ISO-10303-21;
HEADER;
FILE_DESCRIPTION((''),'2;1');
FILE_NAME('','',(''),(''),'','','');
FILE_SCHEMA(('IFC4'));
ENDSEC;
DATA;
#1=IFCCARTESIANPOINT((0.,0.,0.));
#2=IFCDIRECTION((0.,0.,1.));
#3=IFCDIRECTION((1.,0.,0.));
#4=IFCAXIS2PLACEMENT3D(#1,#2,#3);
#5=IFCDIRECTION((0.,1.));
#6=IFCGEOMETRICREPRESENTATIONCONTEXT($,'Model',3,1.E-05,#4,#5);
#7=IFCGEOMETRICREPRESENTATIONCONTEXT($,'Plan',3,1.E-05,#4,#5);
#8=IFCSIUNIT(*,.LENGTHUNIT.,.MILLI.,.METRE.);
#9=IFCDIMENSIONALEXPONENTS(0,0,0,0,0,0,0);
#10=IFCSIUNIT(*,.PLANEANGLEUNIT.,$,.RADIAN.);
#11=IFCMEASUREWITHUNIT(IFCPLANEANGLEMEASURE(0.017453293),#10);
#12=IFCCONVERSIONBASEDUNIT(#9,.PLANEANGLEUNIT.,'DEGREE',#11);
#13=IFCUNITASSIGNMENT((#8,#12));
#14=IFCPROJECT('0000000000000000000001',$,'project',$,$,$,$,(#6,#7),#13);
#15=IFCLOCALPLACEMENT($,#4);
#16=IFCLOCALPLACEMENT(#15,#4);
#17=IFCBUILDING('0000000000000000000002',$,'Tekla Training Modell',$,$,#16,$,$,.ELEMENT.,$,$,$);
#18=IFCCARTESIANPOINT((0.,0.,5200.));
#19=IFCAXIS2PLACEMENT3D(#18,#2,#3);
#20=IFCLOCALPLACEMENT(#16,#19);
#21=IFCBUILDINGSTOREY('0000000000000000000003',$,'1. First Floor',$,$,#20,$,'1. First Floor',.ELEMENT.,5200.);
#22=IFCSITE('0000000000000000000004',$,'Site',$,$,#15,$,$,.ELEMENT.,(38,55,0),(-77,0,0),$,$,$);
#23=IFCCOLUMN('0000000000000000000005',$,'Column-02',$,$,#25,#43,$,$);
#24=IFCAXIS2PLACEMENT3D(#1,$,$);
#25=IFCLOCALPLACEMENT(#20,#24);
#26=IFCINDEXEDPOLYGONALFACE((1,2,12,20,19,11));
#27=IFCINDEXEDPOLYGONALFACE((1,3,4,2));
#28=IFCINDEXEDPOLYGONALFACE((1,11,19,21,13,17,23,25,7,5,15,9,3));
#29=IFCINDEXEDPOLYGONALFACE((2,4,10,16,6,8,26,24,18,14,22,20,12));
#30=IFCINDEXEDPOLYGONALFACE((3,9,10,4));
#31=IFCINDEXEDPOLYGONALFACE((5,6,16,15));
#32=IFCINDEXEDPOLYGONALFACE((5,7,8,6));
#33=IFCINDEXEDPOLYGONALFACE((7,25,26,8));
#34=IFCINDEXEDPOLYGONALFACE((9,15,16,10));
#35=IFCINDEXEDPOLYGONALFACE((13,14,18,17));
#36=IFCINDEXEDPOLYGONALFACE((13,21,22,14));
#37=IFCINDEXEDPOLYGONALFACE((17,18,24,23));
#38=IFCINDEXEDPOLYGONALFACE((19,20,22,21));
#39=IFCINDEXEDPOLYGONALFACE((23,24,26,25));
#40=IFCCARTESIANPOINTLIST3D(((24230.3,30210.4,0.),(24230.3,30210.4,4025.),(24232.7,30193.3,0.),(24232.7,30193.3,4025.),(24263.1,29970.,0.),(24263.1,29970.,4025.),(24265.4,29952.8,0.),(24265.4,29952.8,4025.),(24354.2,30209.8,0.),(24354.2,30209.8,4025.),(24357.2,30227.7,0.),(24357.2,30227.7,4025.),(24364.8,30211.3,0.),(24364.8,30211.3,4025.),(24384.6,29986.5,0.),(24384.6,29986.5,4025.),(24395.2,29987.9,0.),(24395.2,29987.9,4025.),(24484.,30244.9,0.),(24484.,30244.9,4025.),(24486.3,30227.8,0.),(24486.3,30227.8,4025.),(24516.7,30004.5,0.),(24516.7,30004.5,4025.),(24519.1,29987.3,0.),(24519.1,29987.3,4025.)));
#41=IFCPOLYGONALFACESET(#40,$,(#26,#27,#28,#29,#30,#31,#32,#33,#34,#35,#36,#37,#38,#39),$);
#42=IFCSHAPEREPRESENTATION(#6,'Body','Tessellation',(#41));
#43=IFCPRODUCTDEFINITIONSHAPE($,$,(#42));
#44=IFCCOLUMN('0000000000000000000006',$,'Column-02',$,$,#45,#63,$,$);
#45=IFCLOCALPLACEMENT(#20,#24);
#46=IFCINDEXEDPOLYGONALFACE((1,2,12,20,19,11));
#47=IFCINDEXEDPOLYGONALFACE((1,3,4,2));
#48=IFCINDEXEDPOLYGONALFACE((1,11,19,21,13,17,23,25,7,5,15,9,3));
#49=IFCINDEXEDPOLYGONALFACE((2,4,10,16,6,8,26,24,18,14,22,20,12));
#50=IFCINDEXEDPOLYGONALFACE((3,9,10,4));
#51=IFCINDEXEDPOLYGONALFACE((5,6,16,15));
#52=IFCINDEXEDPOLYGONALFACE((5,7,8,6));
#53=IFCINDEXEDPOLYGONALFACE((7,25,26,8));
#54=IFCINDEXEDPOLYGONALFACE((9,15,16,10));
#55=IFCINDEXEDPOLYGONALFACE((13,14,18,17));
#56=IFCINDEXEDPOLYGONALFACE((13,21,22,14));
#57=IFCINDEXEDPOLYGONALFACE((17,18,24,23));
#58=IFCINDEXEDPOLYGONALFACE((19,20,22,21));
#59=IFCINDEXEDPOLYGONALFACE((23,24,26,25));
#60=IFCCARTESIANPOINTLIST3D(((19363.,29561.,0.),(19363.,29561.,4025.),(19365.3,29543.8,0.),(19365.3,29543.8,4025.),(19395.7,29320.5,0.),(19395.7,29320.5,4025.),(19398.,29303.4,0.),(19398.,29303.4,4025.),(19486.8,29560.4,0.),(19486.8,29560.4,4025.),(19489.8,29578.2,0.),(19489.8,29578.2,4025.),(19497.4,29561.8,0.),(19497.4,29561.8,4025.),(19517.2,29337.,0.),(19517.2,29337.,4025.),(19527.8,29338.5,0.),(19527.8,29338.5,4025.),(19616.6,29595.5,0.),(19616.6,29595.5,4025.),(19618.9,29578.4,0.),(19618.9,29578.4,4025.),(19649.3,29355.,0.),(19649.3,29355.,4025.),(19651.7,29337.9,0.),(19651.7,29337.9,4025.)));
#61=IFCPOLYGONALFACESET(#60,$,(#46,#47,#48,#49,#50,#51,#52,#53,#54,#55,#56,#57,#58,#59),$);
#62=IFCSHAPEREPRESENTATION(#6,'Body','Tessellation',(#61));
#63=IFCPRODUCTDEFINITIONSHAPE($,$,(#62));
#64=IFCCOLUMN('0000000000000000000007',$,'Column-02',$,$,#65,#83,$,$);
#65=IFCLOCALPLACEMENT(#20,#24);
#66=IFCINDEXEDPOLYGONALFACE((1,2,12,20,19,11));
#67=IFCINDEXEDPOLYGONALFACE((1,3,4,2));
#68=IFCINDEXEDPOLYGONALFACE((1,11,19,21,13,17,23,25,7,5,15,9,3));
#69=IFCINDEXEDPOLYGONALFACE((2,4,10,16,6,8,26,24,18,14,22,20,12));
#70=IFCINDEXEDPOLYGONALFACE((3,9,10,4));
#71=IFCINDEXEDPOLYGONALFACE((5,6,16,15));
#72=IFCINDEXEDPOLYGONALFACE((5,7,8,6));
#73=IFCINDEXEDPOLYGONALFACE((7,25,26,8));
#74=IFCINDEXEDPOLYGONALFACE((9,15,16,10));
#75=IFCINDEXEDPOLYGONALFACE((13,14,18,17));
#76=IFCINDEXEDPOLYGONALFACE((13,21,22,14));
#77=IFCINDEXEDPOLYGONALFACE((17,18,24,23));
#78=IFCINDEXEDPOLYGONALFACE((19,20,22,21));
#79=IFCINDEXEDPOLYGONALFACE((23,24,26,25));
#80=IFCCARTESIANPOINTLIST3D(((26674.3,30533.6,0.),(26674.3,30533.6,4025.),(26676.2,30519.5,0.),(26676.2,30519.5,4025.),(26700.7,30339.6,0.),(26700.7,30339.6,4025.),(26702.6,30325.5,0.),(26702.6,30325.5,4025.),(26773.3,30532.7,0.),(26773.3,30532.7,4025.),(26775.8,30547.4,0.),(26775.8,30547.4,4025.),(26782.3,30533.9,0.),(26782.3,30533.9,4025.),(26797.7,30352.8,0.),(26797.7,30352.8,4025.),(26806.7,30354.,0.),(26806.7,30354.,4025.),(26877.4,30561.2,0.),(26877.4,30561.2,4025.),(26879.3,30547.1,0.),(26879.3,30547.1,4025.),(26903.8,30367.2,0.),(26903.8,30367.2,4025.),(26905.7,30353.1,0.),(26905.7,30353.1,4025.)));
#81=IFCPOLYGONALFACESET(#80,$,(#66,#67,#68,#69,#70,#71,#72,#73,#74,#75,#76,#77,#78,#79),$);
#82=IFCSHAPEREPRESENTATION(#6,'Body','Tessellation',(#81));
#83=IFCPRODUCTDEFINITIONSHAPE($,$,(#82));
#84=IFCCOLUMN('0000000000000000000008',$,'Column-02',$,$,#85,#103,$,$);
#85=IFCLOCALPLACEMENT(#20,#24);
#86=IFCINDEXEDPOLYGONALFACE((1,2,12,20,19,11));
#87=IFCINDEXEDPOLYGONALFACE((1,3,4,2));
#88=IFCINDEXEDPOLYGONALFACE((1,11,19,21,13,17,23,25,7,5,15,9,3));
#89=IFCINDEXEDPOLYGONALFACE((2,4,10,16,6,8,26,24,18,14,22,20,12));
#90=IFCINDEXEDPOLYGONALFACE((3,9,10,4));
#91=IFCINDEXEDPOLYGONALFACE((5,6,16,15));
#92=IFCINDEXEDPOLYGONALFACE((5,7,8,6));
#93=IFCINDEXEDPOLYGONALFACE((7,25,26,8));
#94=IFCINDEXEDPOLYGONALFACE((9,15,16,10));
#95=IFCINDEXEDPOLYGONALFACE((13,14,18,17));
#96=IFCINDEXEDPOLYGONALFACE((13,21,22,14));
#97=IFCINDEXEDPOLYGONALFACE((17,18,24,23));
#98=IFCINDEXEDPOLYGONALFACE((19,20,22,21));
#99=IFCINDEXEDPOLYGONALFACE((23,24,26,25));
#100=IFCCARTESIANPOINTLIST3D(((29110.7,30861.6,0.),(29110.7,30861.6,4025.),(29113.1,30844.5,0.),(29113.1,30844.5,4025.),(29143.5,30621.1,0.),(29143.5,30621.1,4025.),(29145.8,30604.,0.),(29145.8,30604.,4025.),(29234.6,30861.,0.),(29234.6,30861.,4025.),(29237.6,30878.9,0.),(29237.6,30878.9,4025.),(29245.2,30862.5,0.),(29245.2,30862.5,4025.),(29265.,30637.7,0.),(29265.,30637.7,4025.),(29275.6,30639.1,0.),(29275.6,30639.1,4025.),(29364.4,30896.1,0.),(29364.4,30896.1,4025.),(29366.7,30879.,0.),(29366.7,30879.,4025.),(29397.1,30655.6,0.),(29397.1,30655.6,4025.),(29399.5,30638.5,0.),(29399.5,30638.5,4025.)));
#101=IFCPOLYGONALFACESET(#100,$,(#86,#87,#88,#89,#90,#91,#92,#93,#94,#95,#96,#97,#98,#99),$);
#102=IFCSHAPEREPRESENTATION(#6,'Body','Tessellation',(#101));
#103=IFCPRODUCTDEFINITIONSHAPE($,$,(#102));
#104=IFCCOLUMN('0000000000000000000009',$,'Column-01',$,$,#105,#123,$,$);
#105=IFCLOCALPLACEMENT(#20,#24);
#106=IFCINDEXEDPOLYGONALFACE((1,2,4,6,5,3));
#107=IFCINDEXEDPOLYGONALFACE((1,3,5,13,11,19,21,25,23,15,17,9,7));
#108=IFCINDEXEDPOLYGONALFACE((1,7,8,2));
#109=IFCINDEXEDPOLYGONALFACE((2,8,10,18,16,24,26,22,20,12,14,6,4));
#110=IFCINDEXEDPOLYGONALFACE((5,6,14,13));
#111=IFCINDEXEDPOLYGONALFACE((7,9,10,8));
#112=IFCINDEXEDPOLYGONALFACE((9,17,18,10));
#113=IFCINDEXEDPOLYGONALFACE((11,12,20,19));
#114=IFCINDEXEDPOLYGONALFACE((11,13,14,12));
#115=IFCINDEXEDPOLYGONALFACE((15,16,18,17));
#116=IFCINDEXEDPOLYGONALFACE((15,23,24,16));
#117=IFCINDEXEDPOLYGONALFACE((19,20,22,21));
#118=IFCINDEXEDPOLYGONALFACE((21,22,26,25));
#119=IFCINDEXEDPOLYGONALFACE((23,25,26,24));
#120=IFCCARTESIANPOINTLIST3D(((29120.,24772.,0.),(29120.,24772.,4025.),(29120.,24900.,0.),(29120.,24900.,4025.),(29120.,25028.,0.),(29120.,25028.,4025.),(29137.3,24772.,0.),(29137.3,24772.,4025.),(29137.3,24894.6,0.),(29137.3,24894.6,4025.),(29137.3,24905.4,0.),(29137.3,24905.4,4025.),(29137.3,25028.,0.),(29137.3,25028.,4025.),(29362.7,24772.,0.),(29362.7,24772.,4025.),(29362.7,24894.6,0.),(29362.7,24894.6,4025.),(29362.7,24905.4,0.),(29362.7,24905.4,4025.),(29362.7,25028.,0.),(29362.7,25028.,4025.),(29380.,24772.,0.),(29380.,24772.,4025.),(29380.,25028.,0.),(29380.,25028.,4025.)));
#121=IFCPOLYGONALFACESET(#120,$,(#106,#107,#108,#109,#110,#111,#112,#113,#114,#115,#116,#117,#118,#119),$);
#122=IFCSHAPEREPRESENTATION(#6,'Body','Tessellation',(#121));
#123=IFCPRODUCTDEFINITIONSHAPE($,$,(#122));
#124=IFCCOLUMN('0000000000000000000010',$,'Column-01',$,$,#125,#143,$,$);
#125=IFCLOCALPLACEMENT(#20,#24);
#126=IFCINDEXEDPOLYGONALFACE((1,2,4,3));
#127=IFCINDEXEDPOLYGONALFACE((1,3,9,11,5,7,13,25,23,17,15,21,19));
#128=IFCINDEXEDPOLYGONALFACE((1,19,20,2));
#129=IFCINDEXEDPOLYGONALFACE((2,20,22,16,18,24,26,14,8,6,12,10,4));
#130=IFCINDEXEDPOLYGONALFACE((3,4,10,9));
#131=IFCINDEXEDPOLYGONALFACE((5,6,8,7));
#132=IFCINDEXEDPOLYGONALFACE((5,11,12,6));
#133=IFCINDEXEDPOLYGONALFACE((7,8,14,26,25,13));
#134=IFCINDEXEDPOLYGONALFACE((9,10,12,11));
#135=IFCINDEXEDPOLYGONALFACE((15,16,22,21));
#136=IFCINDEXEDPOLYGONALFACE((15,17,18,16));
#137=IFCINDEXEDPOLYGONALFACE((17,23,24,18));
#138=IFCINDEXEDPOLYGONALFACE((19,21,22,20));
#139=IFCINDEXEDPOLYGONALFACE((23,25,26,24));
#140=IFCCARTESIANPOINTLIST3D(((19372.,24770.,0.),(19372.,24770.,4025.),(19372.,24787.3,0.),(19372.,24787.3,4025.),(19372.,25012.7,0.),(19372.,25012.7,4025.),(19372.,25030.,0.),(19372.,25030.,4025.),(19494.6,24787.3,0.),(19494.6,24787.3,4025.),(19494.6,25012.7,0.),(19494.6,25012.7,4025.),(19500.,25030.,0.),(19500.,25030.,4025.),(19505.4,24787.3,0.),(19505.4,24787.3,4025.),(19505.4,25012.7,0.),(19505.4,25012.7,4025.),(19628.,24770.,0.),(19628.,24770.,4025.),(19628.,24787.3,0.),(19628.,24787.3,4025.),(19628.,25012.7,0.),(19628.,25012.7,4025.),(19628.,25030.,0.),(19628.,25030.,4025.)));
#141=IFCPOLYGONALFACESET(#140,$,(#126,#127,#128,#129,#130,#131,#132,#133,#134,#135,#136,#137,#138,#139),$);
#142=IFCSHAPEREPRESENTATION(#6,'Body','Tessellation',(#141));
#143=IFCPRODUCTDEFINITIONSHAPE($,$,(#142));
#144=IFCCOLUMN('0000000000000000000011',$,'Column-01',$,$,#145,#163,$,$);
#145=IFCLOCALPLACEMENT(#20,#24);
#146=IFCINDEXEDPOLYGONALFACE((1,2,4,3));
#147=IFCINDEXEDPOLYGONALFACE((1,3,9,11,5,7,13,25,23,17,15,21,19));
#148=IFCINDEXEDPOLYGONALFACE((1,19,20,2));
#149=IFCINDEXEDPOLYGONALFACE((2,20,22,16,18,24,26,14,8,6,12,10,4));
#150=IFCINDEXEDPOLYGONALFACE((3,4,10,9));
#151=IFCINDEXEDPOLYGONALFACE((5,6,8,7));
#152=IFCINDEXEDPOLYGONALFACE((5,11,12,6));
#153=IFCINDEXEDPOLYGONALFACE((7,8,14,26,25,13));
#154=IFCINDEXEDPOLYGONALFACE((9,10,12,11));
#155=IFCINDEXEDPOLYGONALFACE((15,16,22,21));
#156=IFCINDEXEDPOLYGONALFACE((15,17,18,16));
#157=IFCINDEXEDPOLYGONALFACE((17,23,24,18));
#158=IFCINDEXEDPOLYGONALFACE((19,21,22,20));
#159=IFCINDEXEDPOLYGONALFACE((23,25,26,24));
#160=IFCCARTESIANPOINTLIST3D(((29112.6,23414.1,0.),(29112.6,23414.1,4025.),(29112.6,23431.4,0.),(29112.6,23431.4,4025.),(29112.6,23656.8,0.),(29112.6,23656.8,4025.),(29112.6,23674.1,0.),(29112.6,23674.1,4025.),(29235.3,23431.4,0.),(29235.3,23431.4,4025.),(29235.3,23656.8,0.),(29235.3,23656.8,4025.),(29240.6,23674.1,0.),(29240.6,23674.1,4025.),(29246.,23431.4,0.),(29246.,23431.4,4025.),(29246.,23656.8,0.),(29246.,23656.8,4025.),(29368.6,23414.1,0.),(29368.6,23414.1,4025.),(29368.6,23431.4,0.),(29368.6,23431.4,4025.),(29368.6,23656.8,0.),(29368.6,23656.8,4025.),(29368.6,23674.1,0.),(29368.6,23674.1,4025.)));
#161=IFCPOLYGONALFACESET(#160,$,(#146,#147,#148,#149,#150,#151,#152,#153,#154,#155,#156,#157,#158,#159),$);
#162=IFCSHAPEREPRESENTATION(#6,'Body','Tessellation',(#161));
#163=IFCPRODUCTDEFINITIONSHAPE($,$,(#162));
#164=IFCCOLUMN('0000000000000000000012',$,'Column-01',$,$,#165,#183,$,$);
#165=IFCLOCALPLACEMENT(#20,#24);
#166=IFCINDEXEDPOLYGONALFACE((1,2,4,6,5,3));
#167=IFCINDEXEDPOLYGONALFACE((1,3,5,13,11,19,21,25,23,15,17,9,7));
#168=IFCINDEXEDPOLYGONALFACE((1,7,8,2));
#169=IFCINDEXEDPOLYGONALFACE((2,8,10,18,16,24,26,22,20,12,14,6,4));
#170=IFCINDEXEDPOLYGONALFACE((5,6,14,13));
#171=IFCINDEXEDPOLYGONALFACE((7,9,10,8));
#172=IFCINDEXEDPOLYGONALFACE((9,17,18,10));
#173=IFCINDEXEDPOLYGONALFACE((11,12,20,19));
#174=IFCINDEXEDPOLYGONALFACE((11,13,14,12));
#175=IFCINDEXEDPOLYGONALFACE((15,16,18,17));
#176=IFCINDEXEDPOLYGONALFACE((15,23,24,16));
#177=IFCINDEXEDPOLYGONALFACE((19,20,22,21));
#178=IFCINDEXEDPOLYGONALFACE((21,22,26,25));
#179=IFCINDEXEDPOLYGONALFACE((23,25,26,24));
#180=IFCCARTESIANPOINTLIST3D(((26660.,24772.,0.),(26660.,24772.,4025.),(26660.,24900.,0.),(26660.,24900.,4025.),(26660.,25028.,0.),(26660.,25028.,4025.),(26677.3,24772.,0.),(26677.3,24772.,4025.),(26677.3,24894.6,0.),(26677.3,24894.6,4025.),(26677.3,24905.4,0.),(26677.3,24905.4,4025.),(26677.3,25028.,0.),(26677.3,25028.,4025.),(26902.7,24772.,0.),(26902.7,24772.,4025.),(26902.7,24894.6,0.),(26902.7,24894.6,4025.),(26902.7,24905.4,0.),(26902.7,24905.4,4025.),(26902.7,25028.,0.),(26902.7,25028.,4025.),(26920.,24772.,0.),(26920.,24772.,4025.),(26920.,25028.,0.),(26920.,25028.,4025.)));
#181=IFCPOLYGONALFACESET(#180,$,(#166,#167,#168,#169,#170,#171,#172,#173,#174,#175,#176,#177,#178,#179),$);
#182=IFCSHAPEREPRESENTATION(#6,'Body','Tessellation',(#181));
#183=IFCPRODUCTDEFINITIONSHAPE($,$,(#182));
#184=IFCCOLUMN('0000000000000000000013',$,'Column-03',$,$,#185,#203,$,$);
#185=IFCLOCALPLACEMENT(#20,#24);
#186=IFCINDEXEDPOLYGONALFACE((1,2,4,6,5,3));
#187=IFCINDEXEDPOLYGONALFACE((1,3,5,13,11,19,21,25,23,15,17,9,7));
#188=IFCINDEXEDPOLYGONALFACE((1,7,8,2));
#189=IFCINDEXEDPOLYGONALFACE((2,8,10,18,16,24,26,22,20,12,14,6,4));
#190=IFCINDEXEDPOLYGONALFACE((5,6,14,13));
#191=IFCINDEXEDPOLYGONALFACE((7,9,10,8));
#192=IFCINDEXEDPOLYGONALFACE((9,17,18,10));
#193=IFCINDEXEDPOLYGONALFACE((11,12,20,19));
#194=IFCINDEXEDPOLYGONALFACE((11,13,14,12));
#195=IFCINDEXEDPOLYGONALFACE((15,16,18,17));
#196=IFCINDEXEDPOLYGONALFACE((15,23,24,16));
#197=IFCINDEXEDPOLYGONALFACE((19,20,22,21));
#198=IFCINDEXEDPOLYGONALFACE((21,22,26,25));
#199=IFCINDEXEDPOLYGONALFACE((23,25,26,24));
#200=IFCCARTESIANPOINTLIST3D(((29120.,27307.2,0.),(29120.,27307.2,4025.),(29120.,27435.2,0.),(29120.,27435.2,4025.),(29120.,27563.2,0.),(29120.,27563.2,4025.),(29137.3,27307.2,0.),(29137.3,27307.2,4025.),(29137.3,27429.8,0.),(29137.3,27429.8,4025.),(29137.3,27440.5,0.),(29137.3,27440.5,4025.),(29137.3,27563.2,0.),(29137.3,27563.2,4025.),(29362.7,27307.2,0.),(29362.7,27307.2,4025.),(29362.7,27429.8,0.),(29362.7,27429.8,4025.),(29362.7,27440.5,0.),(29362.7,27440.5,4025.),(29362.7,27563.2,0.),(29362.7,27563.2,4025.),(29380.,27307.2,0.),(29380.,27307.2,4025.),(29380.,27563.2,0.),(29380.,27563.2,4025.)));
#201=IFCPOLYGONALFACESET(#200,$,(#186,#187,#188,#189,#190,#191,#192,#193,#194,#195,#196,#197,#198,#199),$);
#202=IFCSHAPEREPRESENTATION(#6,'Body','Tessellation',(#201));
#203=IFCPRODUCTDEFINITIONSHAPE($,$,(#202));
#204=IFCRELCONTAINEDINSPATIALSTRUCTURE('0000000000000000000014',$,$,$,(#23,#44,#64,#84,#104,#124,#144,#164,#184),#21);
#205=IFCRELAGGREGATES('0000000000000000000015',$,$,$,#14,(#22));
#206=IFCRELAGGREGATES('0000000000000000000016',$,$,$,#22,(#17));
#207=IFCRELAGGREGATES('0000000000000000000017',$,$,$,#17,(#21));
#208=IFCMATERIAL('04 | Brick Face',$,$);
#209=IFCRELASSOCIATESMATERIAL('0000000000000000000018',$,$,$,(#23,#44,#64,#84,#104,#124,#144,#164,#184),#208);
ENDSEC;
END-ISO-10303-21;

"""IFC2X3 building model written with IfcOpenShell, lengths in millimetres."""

from ifc_helpers import new_model, entity, si_unit, converted_unit, direction, frame, origin_with_axes, place, context, project, spatial, polyline, outline, extrude, material, element, save


model = new_model("IFC2X3")

# Units and contexts
model_context = context("Model", 3, precision=1e-05, world=origin_with_axes(), true_north=direction((0.0, 1.0)))
plan_context = context("Plan", 3, precision=1e-05, world=origin_with_axes(), true_north=direction((0.0, 1.0)))
ifc_project = project(units=[si_unit("LENGTHUNIT", "METRE", prefix="MILLI"), converted_unit("PLANEANGLEUNIT", "DEGREE", entity("IfcPlaneAngleMeasure", 0.017453293), si_unit("PLANEANGLEUNIT", "RADIAN"), dimensions=[0, 0, 0, 0, 0, 0, 0])], contexts=[model_context, plan_context])

# Site, building, storey
site_placement = place(None, origin_with_axes())
site = spatial("IfcSite", under=ifc_project, at=site_placement, Name="Site", CompositionType="ELEMENT", RefLatitude=(38, 55, 0), RefLongitude=(-77, 0, 0))
building_placement = place(site_placement, origin_with_axes())
building = spatial("IfcBuilding", under=site, at=building_placement, Name="Tekla Training Modell", CompositionType="ELEMENT")
storey_placement = place(building_placement, frame((0.0, 0.0, 5200.0), z_axis=(0.0, 0.0, 1.0), x_axis=(1.0, 0.0, 0.0)))
storey = spatial("IfcBuildingStorey", under=building, at=storey_placement, Name="1. First Floor", LongName="1. First Floor", CompositionType="ELEMENT", Elevation=5200.0)

# Columns
ifc_material_1 = material(Name="04 | Brick Face")
for number, where, z_axis, x_axis, name in (
    (1, (24374.7, 30098.9, 0.0), (0.0, 0.0, 1.0), (0.990872, 0.134803, 0.0), "Column-02"),
    (2, (19507.3, 29449.4, 0.0), (0.0, 0.0, 1.0), (0.990872, 0.134803, 0.0), "Column-02"),
):
    element("IfcColumn", number, at=place(storey_placement, frame(where, z_axis=z_axis, x_axis=x_axis)), inside=storey, material=ifc_material_1, Name=name, context=model_context, shape_type="SweptSolid", body=[
        extrude(outline(polyline([(0.0, 130.0), (-128.0, 130.0), (-128.0, 112.7), (-5.3, 112.7), (-5.3, -112.7), (-128.0, -112.7), (-128.0, -130.0), (128.0, -130.0), (128.0, -112.7), (5.3, -112.7), (5.3, 112.7), (128.0, 112.7), (128.0, 130.0), (0.0, 130.0)])), origin_with_axes(), (0.0, 0.0, 1.0), 4025.0),
    ])
column_placement = place(storey_placement, frame((26790.0, 30443.4, 0.0), z_axis=(0.0, 0.0, 1.0), x_axis=(0.990872, 0.134803, 0.0)))
element("IfcColumn", 3, at=column_placement, inside=storey, material=ifc_material_1, Name="Column-02", context=model_context, shape_type="SweptSolid", body=[
    extrude(outline(polyline([(0.0, 105.0), (-102.5, 105.0), (-102.5, 90.8), (-4.5, 90.8), (-4.5, -90.8), (-102.5, -90.8), (-102.5, -105.0), (102.5, -105.0), (102.5, -90.8), (4.5, -90.8), (4.5, 90.8), (102.5, 90.8), (102.5, 105.0), (0.0, 105.0)])), origin_with_axes(), (0.0, 0.0, 1.0), 4025.0),
])
for number, where, z_axis, x_axis, name in (
    (4, (29255.1, 30750.1, 0.0), (0.0, 0.0, 1.0), (0.990872, 0.134803, 0.0), "Column-02"),
    (5, (29250.0, 24900.0, 0.0), (0.0, 0.0, 1.0), (0.0, 1.0, 0.0), "Column-01"),
    (6, (19500.0, 24900.0, 0.0), (0.0, 0.0, 1.0), (1.0, 0.0, 0.0), "Column-01"),
    (7, (29240.6, 23544.1, 0.0), (0.0, 0.0, 1.0), (1.0, 0.0, 0.0), "Column-01"),
    (8, (26790.0, 24900.0, 0.0), (0.0, 0.0, 1.0), (0.0, 1.0, 0.0), "Column-01"),
    (9, (29250.0, 27435.2, 0.0), (0.0, 0.0, 1.0), (0.0, 1.0, 0.0), "Column-03"),
):
    element("IfcColumn", number, at=place(storey_placement, frame(where, z_axis=z_axis, x_axis=x_axis)), inside=storey, material=ifc_material_1, Name=name, context=model_context, shape_type="SweptSolid", body=[
        extrude(outline(polyline([(0.0, 130.0), (-128.0, 130.0), (-128.0, 112.7), (-5.3, 112.7), (-5.3, -112.7), (-128.0, -112.7), (-128.0, -130.0), (128.0, -130.0), (128.0, -112.7), (5.3, -112.7), (5.3, 112.7), (128.0, 112.7), (128.0, 130.0), (0.0, 130.0)])), origin_with_axes(), (0.0, 0.0, 1.0), 4025.0),
    ])

save(model, "model.ifc")
